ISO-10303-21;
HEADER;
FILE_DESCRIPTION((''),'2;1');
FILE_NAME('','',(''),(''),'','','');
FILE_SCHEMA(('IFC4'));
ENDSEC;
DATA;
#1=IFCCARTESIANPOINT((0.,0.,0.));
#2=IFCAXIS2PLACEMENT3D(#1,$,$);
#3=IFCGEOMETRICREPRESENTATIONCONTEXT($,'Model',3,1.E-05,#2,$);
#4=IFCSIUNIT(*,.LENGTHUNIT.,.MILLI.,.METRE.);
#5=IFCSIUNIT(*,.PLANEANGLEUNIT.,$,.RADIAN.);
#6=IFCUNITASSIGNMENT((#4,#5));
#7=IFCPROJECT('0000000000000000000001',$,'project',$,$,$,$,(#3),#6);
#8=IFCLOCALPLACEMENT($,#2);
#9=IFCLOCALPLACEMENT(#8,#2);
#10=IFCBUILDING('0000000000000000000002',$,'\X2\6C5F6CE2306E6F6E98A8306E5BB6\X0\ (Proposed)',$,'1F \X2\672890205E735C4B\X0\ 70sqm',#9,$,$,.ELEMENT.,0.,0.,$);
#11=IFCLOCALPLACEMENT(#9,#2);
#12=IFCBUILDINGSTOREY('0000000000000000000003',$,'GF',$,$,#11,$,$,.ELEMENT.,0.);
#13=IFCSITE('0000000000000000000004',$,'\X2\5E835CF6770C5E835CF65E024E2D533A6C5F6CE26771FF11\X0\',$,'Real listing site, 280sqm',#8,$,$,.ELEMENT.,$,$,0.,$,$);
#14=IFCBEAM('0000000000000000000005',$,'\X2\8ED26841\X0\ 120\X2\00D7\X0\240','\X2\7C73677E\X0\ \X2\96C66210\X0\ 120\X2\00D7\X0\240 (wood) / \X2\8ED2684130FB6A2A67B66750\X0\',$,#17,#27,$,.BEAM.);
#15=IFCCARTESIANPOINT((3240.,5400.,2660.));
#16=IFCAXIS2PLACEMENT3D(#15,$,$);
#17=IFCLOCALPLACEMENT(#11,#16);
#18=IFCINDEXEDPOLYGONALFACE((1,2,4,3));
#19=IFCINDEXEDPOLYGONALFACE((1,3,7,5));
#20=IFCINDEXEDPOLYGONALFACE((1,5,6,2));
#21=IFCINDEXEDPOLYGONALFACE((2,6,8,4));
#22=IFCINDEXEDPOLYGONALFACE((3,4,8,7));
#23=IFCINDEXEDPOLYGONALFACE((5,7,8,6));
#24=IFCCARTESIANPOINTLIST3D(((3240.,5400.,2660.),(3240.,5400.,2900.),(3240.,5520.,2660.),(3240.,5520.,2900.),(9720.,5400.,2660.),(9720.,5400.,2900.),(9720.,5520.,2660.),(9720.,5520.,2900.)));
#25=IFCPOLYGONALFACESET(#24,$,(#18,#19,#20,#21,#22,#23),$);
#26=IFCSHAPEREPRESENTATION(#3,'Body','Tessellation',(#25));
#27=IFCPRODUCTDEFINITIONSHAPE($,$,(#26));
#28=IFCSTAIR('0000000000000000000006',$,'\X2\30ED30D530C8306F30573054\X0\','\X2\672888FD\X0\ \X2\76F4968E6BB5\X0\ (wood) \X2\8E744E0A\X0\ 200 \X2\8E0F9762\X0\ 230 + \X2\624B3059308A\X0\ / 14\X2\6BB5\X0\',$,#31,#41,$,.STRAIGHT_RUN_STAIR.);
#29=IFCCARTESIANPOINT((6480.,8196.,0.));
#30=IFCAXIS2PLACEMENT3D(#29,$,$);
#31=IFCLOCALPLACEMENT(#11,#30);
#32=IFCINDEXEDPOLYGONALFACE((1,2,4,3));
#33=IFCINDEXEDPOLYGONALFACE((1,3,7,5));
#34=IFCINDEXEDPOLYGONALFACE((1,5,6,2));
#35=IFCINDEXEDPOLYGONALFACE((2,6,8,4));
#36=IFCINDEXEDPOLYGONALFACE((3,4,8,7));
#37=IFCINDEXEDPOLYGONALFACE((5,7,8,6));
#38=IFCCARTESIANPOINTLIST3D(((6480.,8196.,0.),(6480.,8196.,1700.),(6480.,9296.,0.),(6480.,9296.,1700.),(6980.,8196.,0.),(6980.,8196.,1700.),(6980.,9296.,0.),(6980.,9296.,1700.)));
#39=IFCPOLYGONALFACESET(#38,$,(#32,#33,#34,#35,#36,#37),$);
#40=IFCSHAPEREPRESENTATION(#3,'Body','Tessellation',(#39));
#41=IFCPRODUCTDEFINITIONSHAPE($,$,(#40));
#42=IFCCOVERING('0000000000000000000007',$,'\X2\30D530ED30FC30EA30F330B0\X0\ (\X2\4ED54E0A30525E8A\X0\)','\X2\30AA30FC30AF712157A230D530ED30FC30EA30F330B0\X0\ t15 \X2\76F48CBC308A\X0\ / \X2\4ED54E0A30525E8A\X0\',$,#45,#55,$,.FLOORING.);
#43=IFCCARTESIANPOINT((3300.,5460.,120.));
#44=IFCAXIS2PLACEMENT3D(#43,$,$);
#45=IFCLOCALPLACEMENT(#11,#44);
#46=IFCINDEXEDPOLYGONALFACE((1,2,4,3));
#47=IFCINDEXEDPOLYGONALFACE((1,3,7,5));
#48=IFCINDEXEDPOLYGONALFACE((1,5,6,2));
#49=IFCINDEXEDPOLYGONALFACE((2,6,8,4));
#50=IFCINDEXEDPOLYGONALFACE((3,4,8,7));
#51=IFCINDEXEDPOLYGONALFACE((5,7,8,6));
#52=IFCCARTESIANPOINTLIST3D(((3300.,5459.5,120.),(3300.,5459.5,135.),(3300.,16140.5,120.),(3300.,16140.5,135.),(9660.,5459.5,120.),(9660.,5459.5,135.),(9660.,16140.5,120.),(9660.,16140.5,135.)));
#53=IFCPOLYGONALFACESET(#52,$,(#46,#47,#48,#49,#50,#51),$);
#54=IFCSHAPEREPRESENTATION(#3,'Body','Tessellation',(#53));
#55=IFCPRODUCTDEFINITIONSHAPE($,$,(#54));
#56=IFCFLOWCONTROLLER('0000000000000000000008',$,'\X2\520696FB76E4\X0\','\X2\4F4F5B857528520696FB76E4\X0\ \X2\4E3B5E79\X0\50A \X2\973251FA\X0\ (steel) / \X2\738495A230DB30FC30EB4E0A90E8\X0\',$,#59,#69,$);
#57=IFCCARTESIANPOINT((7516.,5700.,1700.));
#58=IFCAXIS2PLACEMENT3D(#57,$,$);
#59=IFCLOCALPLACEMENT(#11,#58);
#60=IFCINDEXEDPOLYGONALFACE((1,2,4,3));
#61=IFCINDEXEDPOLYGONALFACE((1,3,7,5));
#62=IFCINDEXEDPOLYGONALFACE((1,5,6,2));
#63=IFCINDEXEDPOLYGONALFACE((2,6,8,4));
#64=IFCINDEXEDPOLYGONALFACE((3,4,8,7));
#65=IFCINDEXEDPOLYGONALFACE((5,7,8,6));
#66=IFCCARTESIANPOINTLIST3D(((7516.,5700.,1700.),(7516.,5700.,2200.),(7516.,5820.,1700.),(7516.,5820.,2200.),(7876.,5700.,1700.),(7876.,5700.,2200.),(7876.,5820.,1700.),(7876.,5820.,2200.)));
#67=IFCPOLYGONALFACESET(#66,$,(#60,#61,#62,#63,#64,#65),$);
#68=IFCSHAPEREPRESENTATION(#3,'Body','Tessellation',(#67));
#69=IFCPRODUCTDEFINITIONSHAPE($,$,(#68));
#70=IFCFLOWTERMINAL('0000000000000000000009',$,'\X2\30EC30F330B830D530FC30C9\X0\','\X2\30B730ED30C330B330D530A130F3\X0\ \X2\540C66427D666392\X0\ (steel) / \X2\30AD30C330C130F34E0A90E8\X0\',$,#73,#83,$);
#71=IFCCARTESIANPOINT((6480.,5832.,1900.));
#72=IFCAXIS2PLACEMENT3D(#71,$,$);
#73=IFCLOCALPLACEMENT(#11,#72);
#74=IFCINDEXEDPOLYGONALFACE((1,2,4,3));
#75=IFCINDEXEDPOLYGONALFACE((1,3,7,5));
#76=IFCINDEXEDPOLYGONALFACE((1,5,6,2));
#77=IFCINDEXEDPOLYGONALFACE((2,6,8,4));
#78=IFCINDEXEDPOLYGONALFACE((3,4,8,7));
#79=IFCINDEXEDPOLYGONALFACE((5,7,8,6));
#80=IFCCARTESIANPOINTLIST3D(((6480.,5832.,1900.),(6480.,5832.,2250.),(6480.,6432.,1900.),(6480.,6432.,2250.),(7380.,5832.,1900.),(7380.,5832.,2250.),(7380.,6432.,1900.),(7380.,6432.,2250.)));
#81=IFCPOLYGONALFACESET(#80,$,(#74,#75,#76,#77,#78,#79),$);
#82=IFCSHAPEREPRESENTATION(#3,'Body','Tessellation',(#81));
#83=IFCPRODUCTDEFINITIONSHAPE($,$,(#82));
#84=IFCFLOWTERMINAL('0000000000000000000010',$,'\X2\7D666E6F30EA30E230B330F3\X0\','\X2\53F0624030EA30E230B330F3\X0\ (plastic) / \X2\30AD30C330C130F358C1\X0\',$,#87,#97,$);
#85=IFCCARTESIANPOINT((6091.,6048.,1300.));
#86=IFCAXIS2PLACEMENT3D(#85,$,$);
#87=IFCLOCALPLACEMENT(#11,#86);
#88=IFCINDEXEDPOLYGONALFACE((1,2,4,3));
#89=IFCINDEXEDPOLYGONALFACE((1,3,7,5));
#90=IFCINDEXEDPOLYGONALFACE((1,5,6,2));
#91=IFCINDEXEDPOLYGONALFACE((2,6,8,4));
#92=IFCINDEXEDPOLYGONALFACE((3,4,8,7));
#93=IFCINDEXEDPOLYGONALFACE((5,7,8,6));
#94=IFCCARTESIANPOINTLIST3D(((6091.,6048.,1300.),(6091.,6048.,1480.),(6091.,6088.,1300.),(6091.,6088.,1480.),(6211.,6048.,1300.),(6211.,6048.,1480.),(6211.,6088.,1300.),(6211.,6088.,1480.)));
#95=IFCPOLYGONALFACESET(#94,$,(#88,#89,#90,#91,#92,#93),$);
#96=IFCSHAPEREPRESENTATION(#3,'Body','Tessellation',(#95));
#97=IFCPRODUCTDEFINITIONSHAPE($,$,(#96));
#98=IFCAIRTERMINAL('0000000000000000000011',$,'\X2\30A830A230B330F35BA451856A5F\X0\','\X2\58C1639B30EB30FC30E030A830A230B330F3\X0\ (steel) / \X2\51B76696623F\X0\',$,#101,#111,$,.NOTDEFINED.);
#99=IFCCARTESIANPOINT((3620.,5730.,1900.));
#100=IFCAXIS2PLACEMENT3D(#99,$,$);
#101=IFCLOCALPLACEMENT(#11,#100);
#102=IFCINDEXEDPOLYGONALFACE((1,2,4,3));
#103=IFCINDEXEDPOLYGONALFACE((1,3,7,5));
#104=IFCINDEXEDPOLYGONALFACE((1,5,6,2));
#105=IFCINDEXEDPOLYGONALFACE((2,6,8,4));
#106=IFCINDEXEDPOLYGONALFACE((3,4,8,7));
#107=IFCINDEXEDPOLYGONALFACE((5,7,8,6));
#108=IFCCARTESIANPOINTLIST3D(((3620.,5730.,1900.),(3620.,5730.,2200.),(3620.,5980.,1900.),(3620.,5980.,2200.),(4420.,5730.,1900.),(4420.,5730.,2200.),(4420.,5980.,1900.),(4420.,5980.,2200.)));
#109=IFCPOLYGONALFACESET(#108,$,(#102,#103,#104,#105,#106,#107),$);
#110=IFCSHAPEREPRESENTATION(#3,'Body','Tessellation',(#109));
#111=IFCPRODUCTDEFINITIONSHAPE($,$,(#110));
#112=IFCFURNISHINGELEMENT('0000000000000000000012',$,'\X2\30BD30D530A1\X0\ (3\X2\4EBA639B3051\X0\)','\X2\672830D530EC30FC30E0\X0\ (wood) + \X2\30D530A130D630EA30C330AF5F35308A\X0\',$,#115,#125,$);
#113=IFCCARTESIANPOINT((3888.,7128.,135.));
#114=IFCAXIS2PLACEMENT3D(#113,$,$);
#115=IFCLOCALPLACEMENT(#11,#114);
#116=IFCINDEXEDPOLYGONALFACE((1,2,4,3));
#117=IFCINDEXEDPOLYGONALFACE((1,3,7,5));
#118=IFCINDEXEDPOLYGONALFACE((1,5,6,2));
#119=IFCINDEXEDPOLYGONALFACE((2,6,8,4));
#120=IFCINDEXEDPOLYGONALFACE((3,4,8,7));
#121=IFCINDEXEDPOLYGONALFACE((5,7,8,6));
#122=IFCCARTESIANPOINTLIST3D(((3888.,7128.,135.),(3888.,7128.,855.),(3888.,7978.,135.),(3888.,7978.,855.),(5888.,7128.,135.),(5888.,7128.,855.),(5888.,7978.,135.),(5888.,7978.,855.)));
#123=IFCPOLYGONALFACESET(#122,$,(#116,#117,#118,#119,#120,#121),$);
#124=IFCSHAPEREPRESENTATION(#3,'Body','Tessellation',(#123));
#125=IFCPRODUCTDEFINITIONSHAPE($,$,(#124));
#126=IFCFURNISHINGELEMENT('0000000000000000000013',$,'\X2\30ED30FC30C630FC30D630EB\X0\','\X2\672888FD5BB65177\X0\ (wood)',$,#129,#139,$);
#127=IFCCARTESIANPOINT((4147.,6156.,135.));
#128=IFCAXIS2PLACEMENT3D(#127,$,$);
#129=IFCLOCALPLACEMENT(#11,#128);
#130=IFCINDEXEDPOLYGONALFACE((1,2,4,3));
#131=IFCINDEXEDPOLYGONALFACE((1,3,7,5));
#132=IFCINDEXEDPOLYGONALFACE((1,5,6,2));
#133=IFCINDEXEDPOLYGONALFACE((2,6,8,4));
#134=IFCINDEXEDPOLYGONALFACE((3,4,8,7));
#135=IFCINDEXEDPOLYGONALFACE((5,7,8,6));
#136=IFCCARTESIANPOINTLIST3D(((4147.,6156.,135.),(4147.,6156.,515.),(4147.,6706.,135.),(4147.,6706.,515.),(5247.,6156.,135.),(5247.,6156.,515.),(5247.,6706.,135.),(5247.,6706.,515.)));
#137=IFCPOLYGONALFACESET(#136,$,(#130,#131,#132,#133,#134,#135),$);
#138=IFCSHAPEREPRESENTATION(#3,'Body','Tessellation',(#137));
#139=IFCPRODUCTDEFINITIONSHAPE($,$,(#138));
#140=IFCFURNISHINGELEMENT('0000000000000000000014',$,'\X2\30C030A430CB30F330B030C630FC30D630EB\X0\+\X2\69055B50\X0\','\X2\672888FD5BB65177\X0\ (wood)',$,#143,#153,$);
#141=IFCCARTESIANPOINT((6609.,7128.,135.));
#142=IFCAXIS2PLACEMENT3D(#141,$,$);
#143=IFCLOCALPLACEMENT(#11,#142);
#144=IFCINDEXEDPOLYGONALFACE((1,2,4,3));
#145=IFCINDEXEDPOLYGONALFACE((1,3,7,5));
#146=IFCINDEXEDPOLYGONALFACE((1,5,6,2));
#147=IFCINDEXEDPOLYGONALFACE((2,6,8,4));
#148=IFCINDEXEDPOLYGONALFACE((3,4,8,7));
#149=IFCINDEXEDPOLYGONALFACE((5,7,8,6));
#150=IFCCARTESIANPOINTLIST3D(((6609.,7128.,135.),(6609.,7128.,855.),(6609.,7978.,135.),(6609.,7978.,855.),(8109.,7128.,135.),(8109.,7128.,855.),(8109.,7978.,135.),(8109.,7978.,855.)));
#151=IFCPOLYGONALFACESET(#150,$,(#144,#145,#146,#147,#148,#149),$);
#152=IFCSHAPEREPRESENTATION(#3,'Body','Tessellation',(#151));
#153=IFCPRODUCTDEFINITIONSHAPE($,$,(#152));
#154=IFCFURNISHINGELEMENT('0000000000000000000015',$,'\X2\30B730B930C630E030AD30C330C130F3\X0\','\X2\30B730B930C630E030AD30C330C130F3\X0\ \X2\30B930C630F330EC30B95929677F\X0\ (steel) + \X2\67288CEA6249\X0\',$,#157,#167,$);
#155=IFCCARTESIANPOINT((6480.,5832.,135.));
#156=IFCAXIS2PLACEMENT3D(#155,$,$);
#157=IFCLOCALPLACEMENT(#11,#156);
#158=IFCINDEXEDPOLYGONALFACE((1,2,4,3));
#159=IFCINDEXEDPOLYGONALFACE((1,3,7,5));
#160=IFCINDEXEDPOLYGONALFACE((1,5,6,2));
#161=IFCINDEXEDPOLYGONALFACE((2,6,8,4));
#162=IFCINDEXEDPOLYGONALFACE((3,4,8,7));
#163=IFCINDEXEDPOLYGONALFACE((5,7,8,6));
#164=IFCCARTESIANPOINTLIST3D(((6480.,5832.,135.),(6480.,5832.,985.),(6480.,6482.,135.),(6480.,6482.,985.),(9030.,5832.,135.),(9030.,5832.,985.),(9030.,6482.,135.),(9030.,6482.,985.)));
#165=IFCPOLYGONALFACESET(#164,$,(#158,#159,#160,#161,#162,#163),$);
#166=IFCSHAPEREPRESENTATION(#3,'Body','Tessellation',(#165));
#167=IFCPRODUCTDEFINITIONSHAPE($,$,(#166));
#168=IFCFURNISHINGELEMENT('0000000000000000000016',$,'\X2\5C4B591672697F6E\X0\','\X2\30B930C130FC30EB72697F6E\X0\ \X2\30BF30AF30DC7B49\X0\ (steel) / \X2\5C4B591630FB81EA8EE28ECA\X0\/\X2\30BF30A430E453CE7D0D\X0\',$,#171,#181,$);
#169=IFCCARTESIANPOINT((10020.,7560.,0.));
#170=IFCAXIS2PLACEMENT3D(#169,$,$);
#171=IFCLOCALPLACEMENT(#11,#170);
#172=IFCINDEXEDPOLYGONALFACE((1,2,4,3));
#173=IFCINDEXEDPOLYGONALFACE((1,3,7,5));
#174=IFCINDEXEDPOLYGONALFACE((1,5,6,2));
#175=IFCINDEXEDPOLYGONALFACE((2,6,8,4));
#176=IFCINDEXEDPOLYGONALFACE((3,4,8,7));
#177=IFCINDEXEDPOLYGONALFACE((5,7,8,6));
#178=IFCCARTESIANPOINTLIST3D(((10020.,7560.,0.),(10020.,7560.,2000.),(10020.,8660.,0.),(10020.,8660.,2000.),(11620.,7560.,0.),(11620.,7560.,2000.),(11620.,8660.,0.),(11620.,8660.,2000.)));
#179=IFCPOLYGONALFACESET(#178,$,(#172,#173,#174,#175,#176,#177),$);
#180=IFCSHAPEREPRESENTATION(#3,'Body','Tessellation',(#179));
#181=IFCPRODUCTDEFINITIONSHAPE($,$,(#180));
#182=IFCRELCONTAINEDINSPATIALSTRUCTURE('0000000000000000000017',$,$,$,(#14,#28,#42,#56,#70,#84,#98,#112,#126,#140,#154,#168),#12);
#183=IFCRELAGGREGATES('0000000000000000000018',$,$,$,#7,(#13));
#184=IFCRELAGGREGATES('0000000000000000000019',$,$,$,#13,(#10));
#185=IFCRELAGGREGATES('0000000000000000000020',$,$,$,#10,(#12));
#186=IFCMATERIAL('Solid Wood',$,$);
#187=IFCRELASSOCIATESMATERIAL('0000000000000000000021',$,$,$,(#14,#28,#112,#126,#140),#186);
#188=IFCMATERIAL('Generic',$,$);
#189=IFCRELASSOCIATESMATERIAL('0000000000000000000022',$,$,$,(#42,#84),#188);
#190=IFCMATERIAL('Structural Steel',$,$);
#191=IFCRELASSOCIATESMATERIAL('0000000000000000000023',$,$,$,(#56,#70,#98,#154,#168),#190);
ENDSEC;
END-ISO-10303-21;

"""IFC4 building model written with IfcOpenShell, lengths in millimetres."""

from ifc_helpers import new_model, si_unit, frame, frame_2d, origin, place, context, project, spatial, rectangle, extrude, material, element, save


model = new_model("IFC4")

# Units and contexts
model_context = context("Model", 3, precision=1e-05, world=origin())
ifc_project = project(units=[si_unit("LENGTHUNIT", "METRE", prefix="MILLI"), si_unit("PLANEANGLEUNIT", "RADIAN")], contexts=[model_context])

# Site, building, storey
site_placement = place(None, origin())
site = spatial("IfcSite", under=ifc_project, at=site_placement, Name="広島県広島市中区江波東１", ObjectType="Real listing site, 280sqm", CompositionType="ELEMENT", RefElevation=0.0)
building_placement = place(site_placement, origin())
building = spatial("IfcBuilding", under=site, at=building_placement, Name="江波の潮風の家 (Proposed)", ObjectType="1F 木造平屋 70sqm", CompositionType="ELEMENT", ElevationOfRefHeight=0.0, ElevationOfTerrain=0.0)
storey_placement = place(building_placement, origin())
storey = spatial("IfcBuildingStorey", under=building, at=storey_placement, Name="GF", CompositionType="ELEMENT", Elevation=0.0)

# Shared definitions
ifc_material_1 = material(Name="Solid Wood")

# Beam
beam_1_placement = place(storey_placement, frame((3240.0, 5400.0, 2660.0)))
element("IfcBeam", 1, at=beam_1_placement, inside=storey, material=ifc_material_1, Name="軒桁 120×240", Description="米松 集成 120×240 (wood) / 軒桁・横架材", PredefinedType="BEAM", context=model_context, shape_type="SweptSolid", body=[
    extrude(rectangle(XDim=6480.0, YDim=120.0, at=frame_2d((3240.0, 60.0))), frame((3240.0, 5400.0, 2660.0)), (0.0, 0.0, 1.0), 240.0),
])

# Stair
stair_placement = place(storey_placement, frame((6480.0, 8196.0, 0.0)))
element("IfcStair", 2, at=stair_placement, inside=storey, material=ifc_material_1, Name="ロフトはしご", Description="木製 直階段 (wood) 蹴上 200 踏面 230 + 手すり / 14段", PredefinedType="STRAIGHT_RUN_STAIR", context=model_context, shape_type="SweptSolid", body=[
    extrude(rectangle(XDim=500.0, YDim=1100.0, at=frame_2d((250.0, 550.0))), frame((6480.0, 8196.0, 0.0)), (0.0, 0.0, 1.0), 1700.0),
])

# Covering
ifc_material_2 = material(Name="Generic")
covering_placement = place(storey_placement, frame((3300.0, 5460.0, 120.0)))
element("IfcCovering", 3, at=covering_placement, inside=storey, material=ifc_material_2, Name="フローリング (仕上げ床)", Description="オーク無垢フローリング t15 直貼り / 仕上げ床", PredefinedType="FLOORING", context=model_context, shape_type="SweptSolid", body=[
    extrude(rectangle(XDim=6360.0, YDim=10681.0, at=frame_2d((3180.0, 5340.0))), frame((3300.0, 5460.0, 120.0)), (0.0, 0.0, 1.0), 15.0),
])

# Flow controller
ifc_material_3 = material(Name="Structural Steel")
flow_controller_placement = place(storey_placement, frame((7516.0, 5700.0, 1700.0)))
element("IfcFlowController", 4, at=flow_controller_placement, inside=storey, material=ifc_material_3, Name="分電盤", Description="住宅用分電盤 主幹50A 露出 (steel) / 玄関ホール上部", context=model_context, shape_type="SweptSolid", body=[
    extrude(rectangle(XDim=360.0, YDim=120.0, at=frame_2d((180.0, 60.0))), frame((7516.0, 5700.0, 1700.0)), (0.0, 0.0, 1.0), 500.0),
])

# Flow terminals
flow_terminal_1_placement = place(storey_placement, frame((6480.0, 5832.0, 1900.0)))
element("IfcFlowTerminal", 5, at=flow_terminal_1_placement, inside=storey, material=ifc_material_3, Name="レンジフード", Description="シロッコファン 同時給排 (steel) / キッチン上部", context=model_context, shape_type="SweptSolid", body=[
    extrude(rectangle(XDim=900.0, YDim=600.0, at=frame_2d((450.0, 300.0))), frame((6480.0, 5832.0, 1900.0)), (0.0, 0.0, 1.0), 350.0),
])
flow_terminal_2_placement = place(storey_placement, frame((6091.0, 6048.0, 1300.0)))
element("IfcFlowTerminal", 6, at=flow_terminal_2_placement, inside=storey, material=ifc_material_2, Name="給湯リモコン", Description="台所リモコン (plastic) / キッチン壁", context=model_context, shape_type="SweptSolid", body=[
    extrude(rectangle(XDim=120.0, YDim=40.0, at=frame_2d((60.0, 20.0))), frame((6091.0, 6048.0, 1300.0)), (0.0, 0.0, 1.0), 180.0),
])

# Air terminal
air_terminal_placement = place(storey_placement, frame((3620.0, 5730.0, 1900.0)))
element("IfcAirTerminal", 7, at=air_terminal_placement, inside=storey, material=ifc_material_3, Name="エアコン室内機", Description="壁掛ルームエアコン (steel) / 冷暖房", PredefinedType="NOTDEFINED", context=model_context, shape_type="SweptSolid", body=[
    extrude(rectangle(XDim=800.0, YDim=250.0, at=frame_2d((400.0, 125.0))), frame((3620.0, 5730.0, 1900.0)), (0.0, 0.0, 1.0), 300.0),
])

# Furnishing elements
furnishing_1_placement = place(storey_placement, frame((3888.0, 7128.0, 135.0)))
element("IfcFurnishingElement", 8, at=furnishing_1_placement, inside=storey, material=ifc_material_1, Name="ソファ (3人掛け)", Description="木フレーム (wood) + ファブリック張り", context=model_context, shape_type="SweptSolid", body=[
    extrude(rectangle(XDim=2000.0, YDim=850.0, at=frame_2d((1000.0, 425.0))), frame((3888.0, 7128.0, 135.0)), (0.0, 0.0, 1.0), 720.0),
])
furnishing_2_placement = place(storey_placement, frame((4147.0, 6156.0, 135.0)))
element("IfcFurnishingElement", 9, at=furnishing_2_placement, inside=storey, material=ifc_material_1, Name="ローテーブル", Description="木製家具 (wood)", context=model_context, shape_type="SweptSolid", body=[
    extrude(rectangle(XDim=1100.0, YDim=550.0, at=frame_2d((550.0, 275.0))), frame((4147.0, 6156.0, 135.0)), (0.0, 0.0, 1.0), 380.0),
])
furnishing_3_placement = place(storey_placement, frame((6609.0, 7128.0, 135.0)))
element("IfcFurnishingElement", 10, at=furnishing_3_placement, inside=storey, material=ifc_material_1, Name="ダイニングテーブル+椅子", Description="木製家具 (wood)", context=model_context, shape_type="SweptSolid", body=[
    extrude(rectangle(XDim=1500.0, YDim=850.0, at=frame_2d((750.0, 425.0))), frame((6609.0, 7128.0, 135.0)), (0.0, 0.0, 1.0), 720.0),
])
furnishing_4_placement = place(storey_placement, frame((6480.0, 5832.0, 135.0)))
element("IfcFurnishingElement", 11, at=furnishing_4_placement, inside=storey, material=ifc_material_3, Name="システムキッチン", Description="システムキッチン ステンレス天板 (steel) + 木質扉", context=model_context, shape_type="SweptSolid", body=[
    extrude(rectangle(XDim=2550.0, YDim=650.0, at=frame_2d((1275.0, 325.0))), frame((6480.0, 5832.0, 135.0)), (0.0, 0.0, 1.0), 850.0),
])
furnishing_5_placement = place(storey_placement, frame((10020.0, 7560.0, 0.0)))
element("IfcFurnishingElement", 12, at=furnishing_5_placement, inside=storey, material=ifc_material_3, Name="屋外物置", Description="スチール物置 タクボ等 (steel) / 屋外・自転車/タイヤ収納", context=model_context, shape_type="SweptSolid", body=[
    extrude(rectangle(XDim=1600.0, YDim=1100.0, at=frame_2d((800.0, 550.0))), frame((10020.0, 7560.0, 0.0)), (0.0, 0.0, 1.0), 2000.0),
])

save(model, "model.ifc")
